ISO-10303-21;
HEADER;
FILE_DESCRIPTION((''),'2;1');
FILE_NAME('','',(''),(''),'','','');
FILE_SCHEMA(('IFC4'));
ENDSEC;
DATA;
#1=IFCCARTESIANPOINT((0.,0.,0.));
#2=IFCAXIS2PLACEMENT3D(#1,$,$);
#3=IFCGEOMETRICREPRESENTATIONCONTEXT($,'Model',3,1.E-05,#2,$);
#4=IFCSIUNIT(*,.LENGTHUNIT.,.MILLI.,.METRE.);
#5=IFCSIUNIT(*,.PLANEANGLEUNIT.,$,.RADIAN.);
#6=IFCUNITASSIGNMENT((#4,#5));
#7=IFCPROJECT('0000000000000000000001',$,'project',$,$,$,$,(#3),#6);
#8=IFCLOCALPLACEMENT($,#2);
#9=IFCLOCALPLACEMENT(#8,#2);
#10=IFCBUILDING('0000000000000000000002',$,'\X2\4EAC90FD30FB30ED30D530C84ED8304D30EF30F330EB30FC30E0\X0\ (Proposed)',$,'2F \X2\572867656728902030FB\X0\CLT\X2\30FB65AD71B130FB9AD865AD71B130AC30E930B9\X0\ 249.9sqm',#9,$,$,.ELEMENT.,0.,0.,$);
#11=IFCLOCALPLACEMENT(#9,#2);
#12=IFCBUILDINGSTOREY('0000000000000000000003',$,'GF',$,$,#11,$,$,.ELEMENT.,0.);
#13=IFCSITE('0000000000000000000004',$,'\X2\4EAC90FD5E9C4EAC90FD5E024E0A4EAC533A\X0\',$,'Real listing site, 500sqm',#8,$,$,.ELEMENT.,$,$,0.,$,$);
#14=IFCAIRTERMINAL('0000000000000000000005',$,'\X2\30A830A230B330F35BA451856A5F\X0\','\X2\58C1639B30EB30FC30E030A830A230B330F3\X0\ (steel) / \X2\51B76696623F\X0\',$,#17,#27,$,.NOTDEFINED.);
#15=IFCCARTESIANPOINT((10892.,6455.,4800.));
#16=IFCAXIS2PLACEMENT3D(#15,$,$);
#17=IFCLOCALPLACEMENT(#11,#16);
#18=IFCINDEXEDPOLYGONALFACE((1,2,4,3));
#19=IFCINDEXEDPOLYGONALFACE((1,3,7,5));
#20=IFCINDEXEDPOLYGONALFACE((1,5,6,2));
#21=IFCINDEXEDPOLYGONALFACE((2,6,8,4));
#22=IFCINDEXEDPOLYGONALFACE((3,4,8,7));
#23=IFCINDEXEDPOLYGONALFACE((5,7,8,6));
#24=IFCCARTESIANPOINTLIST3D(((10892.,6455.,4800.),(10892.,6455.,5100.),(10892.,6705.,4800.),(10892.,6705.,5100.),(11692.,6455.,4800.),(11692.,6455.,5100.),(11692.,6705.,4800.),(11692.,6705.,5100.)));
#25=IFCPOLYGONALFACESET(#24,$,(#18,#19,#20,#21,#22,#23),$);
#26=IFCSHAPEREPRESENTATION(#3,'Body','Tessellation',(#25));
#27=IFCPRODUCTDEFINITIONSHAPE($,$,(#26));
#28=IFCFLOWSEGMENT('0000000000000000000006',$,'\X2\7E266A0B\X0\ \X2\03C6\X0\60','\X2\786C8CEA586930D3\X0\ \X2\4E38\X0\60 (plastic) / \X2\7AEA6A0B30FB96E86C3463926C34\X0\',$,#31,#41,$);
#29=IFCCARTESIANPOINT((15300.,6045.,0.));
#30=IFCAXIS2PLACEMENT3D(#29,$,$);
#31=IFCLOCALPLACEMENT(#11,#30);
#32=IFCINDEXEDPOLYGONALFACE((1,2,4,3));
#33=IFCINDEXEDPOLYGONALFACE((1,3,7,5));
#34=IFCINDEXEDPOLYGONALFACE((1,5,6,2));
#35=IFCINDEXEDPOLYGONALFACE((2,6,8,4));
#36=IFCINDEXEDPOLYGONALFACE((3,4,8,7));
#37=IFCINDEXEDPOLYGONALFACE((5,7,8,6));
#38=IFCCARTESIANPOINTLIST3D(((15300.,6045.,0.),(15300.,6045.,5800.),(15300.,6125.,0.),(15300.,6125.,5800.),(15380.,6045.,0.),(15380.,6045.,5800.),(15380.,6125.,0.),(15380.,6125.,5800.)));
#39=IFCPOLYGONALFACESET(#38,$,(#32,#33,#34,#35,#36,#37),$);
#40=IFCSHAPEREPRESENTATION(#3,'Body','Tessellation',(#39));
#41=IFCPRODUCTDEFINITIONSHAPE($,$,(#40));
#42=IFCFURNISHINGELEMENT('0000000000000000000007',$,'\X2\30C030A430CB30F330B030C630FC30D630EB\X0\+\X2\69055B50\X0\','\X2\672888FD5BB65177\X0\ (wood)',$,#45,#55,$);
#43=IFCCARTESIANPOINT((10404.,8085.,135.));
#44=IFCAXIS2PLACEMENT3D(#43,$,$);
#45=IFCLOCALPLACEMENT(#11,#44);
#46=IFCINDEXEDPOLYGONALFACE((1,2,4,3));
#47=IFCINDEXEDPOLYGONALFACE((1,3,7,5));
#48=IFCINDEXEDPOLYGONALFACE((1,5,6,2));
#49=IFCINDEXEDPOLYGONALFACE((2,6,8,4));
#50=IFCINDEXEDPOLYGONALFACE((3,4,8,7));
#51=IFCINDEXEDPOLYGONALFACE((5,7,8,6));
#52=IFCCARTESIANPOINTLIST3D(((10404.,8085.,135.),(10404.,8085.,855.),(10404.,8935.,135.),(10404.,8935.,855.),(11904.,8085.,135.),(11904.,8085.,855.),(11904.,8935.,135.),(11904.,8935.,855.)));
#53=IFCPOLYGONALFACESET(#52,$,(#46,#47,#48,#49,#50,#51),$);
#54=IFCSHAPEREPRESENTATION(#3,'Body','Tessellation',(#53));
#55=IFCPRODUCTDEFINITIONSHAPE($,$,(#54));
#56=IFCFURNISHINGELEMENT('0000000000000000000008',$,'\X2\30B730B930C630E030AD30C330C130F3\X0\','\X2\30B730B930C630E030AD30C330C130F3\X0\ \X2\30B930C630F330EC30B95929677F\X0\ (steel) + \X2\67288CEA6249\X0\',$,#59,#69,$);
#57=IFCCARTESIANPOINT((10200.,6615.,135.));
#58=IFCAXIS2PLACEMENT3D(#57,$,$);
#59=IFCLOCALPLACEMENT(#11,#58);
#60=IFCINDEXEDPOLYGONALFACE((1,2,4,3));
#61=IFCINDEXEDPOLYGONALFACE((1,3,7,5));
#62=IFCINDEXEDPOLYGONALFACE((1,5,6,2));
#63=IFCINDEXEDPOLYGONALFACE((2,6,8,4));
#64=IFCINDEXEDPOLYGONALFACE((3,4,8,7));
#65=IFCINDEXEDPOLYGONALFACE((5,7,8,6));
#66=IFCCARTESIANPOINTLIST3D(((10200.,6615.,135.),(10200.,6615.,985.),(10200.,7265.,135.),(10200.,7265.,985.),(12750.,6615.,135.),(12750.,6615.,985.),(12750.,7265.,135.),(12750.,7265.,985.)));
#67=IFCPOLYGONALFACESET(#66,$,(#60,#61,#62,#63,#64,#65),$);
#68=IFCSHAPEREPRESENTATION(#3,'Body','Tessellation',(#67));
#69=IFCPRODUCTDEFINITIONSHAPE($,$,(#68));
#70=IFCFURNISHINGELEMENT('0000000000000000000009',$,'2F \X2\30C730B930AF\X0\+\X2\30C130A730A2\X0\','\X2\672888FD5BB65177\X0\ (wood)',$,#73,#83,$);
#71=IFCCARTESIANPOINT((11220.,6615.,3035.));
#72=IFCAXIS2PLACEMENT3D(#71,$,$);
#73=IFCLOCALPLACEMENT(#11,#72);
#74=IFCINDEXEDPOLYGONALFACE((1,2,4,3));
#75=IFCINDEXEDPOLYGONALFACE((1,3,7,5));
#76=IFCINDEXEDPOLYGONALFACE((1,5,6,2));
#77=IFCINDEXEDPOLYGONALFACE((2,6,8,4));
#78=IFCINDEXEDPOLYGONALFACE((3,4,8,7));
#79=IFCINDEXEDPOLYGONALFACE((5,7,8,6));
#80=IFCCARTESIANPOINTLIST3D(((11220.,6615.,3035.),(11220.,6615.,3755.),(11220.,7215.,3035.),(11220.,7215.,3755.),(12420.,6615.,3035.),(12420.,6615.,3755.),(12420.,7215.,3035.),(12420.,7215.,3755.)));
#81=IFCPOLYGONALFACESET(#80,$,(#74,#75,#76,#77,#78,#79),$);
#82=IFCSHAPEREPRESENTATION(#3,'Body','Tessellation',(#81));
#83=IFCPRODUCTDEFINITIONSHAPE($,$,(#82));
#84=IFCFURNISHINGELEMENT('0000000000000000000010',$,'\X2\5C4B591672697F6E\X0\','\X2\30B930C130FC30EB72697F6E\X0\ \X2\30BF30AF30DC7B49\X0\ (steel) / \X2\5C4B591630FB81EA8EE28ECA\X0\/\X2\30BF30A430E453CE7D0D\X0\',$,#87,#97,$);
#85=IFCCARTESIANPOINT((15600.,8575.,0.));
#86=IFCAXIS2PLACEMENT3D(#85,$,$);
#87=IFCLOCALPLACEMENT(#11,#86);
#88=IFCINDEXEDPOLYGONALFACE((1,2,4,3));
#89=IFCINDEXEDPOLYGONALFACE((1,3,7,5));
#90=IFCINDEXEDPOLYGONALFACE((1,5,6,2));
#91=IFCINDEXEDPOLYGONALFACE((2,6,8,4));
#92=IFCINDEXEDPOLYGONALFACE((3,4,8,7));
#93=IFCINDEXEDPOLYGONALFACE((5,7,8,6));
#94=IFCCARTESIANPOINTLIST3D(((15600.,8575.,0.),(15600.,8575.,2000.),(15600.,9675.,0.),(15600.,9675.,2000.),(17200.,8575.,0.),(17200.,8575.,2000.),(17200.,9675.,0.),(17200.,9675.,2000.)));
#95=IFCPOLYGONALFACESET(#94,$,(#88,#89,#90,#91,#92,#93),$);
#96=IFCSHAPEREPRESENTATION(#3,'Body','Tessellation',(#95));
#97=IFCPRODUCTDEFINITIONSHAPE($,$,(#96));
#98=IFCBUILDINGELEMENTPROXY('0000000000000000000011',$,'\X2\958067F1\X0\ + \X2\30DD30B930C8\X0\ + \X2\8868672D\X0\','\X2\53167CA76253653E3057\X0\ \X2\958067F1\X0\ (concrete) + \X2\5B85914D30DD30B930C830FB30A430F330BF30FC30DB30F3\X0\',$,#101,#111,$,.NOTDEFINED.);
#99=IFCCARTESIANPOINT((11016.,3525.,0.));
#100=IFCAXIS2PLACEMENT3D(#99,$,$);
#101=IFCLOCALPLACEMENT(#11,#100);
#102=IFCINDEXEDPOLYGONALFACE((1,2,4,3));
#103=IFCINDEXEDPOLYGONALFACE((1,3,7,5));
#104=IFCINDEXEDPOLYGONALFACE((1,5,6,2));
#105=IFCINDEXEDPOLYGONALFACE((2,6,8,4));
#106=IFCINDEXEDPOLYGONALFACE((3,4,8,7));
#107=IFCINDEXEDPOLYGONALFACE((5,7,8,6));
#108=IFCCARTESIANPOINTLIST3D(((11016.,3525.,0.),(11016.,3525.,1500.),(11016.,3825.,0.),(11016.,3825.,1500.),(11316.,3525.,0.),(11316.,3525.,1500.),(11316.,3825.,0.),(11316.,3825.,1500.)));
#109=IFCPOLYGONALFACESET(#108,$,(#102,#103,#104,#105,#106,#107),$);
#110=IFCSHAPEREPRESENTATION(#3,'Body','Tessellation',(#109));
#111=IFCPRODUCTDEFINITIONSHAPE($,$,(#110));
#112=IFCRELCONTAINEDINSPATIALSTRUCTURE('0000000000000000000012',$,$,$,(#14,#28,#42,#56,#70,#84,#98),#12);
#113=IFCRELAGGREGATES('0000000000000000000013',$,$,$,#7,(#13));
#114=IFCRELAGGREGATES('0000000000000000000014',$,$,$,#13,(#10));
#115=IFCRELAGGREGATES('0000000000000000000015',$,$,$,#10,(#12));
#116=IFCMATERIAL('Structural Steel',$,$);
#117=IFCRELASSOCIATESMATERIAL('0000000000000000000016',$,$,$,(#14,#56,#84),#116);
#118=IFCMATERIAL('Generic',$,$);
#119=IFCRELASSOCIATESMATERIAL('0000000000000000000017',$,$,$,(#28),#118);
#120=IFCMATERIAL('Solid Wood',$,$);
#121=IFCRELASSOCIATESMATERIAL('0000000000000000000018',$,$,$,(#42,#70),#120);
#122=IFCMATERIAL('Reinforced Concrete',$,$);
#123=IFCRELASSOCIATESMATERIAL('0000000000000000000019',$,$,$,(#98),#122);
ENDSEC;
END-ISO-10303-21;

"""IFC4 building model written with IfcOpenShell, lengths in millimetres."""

from ifc_helpers import new_model, si_unit, frame, frame_2d, origin, place, context, project, spatial, rectangle, extrude, material, element, save


model = new_model("IFC4")

# Units and contexts
model_context = context("Model", 3, precision=1e-05, world=origin())
ifc_project = project(units=[si_unit("LENGTHUNIT", "METRE", prefix="MILLI"), si_unit("PLANEANGLEUNIT", "RADIAN")], contexts=[model_context])

# Site, building, storey
site_placement = place(None, origin())
site = spatial("IfcSite", under=ifc_project, at=site_placement, Name="京都府京都市上京区", ObjectType="Real listing site, 500sqm", CompositionType="ELEMENT", RefElevation=0.0)
building_placement = place(site_placement, origin())
building = spatial("IfcBuilding", under=site, at=building_placement, Name="京都・ロフト付きワンルーム (Proposed)", ObjectType="2F 在来木造・CLT・断熱・高断熱ガラス 249.9sqm", CompositionType="ELEMENT", ElevationOfRefHeight=0.0, ElevationOfTerrain=0.0)
storey_placement = place(building_placement, origin())
storey = spatial("IfcBuildingStorey", under=building, at=storey_placement, Name="GF", CompositionType="ELEMENT", Elevation=0.0)

# Shared definitions
ifc_material_1 = material(Name="Solid Wood")

# Shared definitions
ifc_material_2 = material(Name="Reinforced Concrete")

# Shared definitions
ifc_material_3 = material(Name="Structural Steel")

# Shared definitions
ifc_material_4 = material(Name="Generic")

# Air terminal
air_terminal_placement = place(storey_placement, frame((10892.0, 6455.0, 4800.0)))
element("IfcAirTerminal", 1, at=air_terminal_placement, inside=storey, material=ifc_material_3, Name="エアコン室内機", Description="壁掛ルームエアコン (steel) / 冷暖房", PredefinedType="NOTDEFINED", context=model_context, shape_type="SweptSolid", body=[
    extrude(rectangle(XDim=800.0, YDim=250.0, at=frame_2d((400.0, 125.0))), frame((10892.0, 6455.0, 4800.0)), (0.0, 0.0, 1.0), 300.0),
])

# Flow segment
flow_segment_placement = place(storey_placement, frame((15300.0, 6045.0, 0.0)))
element("IfcFlowSegment", 2, at=flow_segment_placement, inside=storey, material=ifc_material_4, Name="縦樋 φ60", Description="硬質塩ビ 丸60 (plastic) / 竪樋・雨水排水", context=model_context, shape_type="SweptSolid", body=[
    extrude(rectangle(XDim=80.0, YDim=80.0, at=frame_2d((40.0, 40.0))), frame((15300.0, 6045.0, 0.0)), (0.0, 0.0, 1.0), 5800.0),
])

# Furnishing elements
furnishing_1_placement = place(storey_placement, frame((10404.0, 8085.0, 135.0)))
element("IfcFurnishingElement", 3, at=furnishing_1_placement, inside=storey, material=ifc_material_1, Name="ダイニングテーブル+椅子", Description="木製家具 (wood)", context=model_context, shape_type="SweptSolid", body=[
    extrude(rectangle(XDim=1500.0, YDim=850.0, at=frame_2d((750.0, 425.0))), frame((10404.0, 8085.0, 135.0)), (0.0, 0.0, 1.0), 720.0),
])
furnishing_2_placement = place(storey_placement, frame((10200.0, 6615.0, 135.0)))
element("IfcFurnishingElement", 4, at=furnishing_2_placement, inside=storey, material=ifc_material_3, Name="システムキッチン", Description="システムキッチン ステンレス天板 (steel) + 木質扉", context=model_context, shape_type="SweptSolid", body=[
    extrude(rectangle(XDim=2550.0, YDim=650.0, at=frame_2d((1275.0, 325.0))), frame((10200.0, 6615.0, 135.0)), (0.0, 0.0, 1.0), 850.0),
])
furnishing_3_placement = place(storey_placement, frame((11220.0, 6615.0, 3035.0)))
element("IfcFurnishingElement", 5, at=furnishing_3_placement, inside=storey, material=ifc_material_1, Name="2F デスク+チェア", Description="木製家具 (wood)", context=model_context, shape_type="SweptSolid", body=[
    extrude(rectangle(XDim=1200.0, YDim=600.0, at=frame_2d((600.0, 300.0))), frame((11220.0, 6615.0, 3035.0)), (0.0, 0.0, 1.0), 720.0),
])
furnishing_4_placement = place(storey_placement, frame((15600.0, 8575.0, 0.0)))
element("IfcFurnishingElement", 6, at=furnishing_4_placement, inside=storey, material=ifc_material_3, Name="屋外物置", Description="スチール物置 タクボ等 (steel) / 屋外・自転車/タイヤ収納", context=model_context, shape_type="SweptSolid", body=[
    extrude(rectangle(XDim=1600.0, YDim=1100.0, at=frame_2d((800.0, 550.0))), frame((15600.0, 8575.0, 0.0)), (0.0, 0.0, 1.0), 2000.0),
])

# Building element proxy
proxy_placement = place(storey_placement, frame((11016.0, 3525.0, 0.0)))
element("IfcBuildingElementProxy", 7, at=proxy_placement, inside=storey, material=ifc_material_2, Name="門柱 + ポスト + 表札", Description="化粧打放し 門柱 (concrete) + 宅配ポスト・インターホン", PredefinedType="NOTDEFINED", context=model_context, shape_type="SweptSolid", body=[
    extrude(rectangle(XDim=300.0, YDim=300.0, at=frame_2d((150.0, 150.0))), frame((11016.0, 3525.0, 0.0)), (0.0, 0.0, 1.0), 1500.0),
])

save(model, "model.ifc")
